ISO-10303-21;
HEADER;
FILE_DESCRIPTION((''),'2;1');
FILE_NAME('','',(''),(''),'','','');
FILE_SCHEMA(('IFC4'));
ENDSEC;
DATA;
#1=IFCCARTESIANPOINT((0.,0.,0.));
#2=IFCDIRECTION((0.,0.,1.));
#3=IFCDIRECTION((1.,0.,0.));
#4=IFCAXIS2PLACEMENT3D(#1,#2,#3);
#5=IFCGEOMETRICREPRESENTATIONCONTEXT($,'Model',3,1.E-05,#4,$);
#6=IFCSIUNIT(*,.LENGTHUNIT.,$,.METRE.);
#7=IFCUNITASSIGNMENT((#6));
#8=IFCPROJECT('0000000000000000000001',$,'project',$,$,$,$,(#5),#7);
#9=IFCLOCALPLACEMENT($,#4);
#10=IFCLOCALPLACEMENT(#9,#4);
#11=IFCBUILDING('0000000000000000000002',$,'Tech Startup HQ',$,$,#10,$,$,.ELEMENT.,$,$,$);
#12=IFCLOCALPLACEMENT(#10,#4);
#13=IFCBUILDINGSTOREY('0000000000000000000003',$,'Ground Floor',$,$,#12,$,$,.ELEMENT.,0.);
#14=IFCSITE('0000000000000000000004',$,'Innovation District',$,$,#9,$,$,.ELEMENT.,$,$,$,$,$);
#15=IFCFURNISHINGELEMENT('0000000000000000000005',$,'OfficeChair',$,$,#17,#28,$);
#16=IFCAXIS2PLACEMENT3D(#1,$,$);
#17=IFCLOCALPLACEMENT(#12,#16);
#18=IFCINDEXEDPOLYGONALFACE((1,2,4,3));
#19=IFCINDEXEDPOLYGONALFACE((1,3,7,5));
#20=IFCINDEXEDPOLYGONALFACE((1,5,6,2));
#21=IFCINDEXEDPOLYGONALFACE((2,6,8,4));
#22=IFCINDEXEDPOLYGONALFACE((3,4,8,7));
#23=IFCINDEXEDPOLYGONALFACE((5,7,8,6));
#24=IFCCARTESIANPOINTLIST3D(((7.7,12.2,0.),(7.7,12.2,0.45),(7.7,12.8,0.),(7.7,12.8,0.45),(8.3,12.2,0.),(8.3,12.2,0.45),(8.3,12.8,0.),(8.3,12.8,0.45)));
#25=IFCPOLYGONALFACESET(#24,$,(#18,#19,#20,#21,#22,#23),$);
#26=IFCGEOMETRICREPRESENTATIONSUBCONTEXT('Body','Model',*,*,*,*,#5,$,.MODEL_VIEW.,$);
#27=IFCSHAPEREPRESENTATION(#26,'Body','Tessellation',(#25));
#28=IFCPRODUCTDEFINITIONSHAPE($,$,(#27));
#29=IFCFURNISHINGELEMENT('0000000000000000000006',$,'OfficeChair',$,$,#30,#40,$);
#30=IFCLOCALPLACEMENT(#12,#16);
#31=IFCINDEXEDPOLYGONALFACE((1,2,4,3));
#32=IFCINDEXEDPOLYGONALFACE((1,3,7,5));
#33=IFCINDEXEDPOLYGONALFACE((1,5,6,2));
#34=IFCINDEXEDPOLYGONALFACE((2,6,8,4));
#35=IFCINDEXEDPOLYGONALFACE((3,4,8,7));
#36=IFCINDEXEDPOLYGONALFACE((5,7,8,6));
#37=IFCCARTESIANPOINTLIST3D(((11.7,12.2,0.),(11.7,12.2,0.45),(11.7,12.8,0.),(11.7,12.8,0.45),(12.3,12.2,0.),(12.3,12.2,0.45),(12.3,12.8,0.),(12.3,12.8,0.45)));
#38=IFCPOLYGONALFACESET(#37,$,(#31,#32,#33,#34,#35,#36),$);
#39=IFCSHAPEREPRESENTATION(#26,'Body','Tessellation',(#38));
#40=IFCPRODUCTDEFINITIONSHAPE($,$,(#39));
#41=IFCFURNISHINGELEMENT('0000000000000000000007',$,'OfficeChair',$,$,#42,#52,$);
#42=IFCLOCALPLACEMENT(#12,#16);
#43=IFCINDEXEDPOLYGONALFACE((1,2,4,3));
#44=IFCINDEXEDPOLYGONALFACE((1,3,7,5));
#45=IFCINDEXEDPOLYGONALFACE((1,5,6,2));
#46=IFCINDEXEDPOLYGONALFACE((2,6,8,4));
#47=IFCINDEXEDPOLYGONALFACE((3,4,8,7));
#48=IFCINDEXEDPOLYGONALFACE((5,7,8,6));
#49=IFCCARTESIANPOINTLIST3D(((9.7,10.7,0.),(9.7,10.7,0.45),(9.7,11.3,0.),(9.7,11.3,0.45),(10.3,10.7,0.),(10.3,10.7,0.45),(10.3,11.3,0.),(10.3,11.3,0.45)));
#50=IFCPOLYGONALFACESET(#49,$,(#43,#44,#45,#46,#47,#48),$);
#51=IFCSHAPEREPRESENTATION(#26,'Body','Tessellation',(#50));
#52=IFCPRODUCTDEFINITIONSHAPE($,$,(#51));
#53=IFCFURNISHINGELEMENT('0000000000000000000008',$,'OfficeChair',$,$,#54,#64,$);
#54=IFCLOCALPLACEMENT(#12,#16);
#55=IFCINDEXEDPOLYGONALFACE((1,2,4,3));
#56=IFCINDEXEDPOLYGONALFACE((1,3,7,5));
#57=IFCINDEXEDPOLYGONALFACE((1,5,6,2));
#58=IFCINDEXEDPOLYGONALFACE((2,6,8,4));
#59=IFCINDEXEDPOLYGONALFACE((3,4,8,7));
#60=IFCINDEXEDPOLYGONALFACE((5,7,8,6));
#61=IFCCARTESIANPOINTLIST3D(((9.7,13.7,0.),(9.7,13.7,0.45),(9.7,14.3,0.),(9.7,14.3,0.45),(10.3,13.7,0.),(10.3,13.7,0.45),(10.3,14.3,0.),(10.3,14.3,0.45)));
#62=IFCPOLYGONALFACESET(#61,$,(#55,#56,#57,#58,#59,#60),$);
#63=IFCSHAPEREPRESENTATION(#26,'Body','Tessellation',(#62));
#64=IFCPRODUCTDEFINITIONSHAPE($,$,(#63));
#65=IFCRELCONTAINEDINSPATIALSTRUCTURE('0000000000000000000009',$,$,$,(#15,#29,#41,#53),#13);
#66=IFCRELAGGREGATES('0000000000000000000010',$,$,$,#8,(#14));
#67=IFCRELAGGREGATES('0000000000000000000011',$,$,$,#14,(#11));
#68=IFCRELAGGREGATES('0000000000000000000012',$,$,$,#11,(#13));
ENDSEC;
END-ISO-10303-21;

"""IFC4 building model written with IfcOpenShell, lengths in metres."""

from ifc_helpers import new_model, si_unit, origin_with_axes, place, context, subcontext, project, spatial, polyline, outline, extrude, element, save


model = new_model("IFC4")

# Units and contexts
model_context = context("Model", 3, precision=1e-05, world=origin_with_axes())
body_context = subcontext(model_context, "Body", "Model", "MODEL_VIEW")
ifc_project = project(units=[si_unit("LENGTHUNIT", "METRE")], contexts=[model_context])

# Site, building, storey
site_placement = place(None, origin_with_axes())
site = spatial("IfcSite", under=ifc_project, at=site_placement, Name="Innovation District", CompositionType="ELEMENT")
building_placement = place(site_placement, origin_with_axes())
building = spatial("IfcBuilding", under=site, at=building_placement, Name="Tech Startup HQ", CompositionType="ELEMENT")
storey_placement = place(building_placement, origin_with_axes())
storey = spatial("IfcBuildingStorey", under=building, at=storey_placement, Name="Ground Floor", CompositionType="ELEMENT", Elevation=0.0)

# Furnishing elements
furnishing_1_placement = place(storey_placement, origin_with_axes())
element("IfcFurnishingElement", 1, at=furnishing_1_placement, inside=storey, Name="OfficeChair", context=body_context, shape_type="SweptSolid", body=[
    extrude(outline(polyline([(7.7, 12.8, 0.0), (7.7, 12.2, 0.0), (8.3, 12.2, 0.0), (8.3, 12.8, 0.0), (7.7, 12.8, 0.0)])), None, (0.0, 0.0, 1.0), 0.45),
])
furnishing_2_placement = place(storey_placement, origin_with_axes())
element("IfcFurnishingElement", 2, at=furnishing_2_placement, inside=storey, Name="OfficeChair", context=body_context, shape_type="SweptSolid", body=[
    extrude(outline(polyline([(12.3, 12.2, 0.0), (12.3, 12.8, 0.0), (11.7, 12.8, 0.0), (11.7, 12.2, 0.0), (12.3, 12.2, 0.0)])), None, (0.0, 0.0, 1.0), 0.45),
])
furnishing_3_placement = place(storey_placement, origin_with_axes())
element("IfcFurnishingElement", 3, at=furnishing_3_placement, inside=storey, Name="OfficeChair", context=body_context, shape_type="SweptSolid", body=[
    extrude(outline(polyline([(9.7, 10.7, 0.0), (10.3, 10.7, 0.0), (10.3, 11.3, 0.0), (9.7, 11.3, 0.0), (9.7, 10.7, 0.0)])), None, (0.0, 0.0, 1.0), 0.45),
])
furnishing_4_placement = place(storey_placement, origin_with_axes())
element("IfcFurnishingElement", 4, at=furnishing_4_placement, inside=storey, Name="OfficeChair", context=body_context, shape_type="SweptSolid", body=[
    extrude(outline(polyline([(10.3, 14.3, 0.0), (9.7, 14.3, 0.0), (9.7, 13.7, 0.0), (10.3, 13.7, 0.0), (10.3, 14.3, 0.0)])), None, (0.0, 0.0, 1.0), 0.45),
])

save(model, "model.ifc")
